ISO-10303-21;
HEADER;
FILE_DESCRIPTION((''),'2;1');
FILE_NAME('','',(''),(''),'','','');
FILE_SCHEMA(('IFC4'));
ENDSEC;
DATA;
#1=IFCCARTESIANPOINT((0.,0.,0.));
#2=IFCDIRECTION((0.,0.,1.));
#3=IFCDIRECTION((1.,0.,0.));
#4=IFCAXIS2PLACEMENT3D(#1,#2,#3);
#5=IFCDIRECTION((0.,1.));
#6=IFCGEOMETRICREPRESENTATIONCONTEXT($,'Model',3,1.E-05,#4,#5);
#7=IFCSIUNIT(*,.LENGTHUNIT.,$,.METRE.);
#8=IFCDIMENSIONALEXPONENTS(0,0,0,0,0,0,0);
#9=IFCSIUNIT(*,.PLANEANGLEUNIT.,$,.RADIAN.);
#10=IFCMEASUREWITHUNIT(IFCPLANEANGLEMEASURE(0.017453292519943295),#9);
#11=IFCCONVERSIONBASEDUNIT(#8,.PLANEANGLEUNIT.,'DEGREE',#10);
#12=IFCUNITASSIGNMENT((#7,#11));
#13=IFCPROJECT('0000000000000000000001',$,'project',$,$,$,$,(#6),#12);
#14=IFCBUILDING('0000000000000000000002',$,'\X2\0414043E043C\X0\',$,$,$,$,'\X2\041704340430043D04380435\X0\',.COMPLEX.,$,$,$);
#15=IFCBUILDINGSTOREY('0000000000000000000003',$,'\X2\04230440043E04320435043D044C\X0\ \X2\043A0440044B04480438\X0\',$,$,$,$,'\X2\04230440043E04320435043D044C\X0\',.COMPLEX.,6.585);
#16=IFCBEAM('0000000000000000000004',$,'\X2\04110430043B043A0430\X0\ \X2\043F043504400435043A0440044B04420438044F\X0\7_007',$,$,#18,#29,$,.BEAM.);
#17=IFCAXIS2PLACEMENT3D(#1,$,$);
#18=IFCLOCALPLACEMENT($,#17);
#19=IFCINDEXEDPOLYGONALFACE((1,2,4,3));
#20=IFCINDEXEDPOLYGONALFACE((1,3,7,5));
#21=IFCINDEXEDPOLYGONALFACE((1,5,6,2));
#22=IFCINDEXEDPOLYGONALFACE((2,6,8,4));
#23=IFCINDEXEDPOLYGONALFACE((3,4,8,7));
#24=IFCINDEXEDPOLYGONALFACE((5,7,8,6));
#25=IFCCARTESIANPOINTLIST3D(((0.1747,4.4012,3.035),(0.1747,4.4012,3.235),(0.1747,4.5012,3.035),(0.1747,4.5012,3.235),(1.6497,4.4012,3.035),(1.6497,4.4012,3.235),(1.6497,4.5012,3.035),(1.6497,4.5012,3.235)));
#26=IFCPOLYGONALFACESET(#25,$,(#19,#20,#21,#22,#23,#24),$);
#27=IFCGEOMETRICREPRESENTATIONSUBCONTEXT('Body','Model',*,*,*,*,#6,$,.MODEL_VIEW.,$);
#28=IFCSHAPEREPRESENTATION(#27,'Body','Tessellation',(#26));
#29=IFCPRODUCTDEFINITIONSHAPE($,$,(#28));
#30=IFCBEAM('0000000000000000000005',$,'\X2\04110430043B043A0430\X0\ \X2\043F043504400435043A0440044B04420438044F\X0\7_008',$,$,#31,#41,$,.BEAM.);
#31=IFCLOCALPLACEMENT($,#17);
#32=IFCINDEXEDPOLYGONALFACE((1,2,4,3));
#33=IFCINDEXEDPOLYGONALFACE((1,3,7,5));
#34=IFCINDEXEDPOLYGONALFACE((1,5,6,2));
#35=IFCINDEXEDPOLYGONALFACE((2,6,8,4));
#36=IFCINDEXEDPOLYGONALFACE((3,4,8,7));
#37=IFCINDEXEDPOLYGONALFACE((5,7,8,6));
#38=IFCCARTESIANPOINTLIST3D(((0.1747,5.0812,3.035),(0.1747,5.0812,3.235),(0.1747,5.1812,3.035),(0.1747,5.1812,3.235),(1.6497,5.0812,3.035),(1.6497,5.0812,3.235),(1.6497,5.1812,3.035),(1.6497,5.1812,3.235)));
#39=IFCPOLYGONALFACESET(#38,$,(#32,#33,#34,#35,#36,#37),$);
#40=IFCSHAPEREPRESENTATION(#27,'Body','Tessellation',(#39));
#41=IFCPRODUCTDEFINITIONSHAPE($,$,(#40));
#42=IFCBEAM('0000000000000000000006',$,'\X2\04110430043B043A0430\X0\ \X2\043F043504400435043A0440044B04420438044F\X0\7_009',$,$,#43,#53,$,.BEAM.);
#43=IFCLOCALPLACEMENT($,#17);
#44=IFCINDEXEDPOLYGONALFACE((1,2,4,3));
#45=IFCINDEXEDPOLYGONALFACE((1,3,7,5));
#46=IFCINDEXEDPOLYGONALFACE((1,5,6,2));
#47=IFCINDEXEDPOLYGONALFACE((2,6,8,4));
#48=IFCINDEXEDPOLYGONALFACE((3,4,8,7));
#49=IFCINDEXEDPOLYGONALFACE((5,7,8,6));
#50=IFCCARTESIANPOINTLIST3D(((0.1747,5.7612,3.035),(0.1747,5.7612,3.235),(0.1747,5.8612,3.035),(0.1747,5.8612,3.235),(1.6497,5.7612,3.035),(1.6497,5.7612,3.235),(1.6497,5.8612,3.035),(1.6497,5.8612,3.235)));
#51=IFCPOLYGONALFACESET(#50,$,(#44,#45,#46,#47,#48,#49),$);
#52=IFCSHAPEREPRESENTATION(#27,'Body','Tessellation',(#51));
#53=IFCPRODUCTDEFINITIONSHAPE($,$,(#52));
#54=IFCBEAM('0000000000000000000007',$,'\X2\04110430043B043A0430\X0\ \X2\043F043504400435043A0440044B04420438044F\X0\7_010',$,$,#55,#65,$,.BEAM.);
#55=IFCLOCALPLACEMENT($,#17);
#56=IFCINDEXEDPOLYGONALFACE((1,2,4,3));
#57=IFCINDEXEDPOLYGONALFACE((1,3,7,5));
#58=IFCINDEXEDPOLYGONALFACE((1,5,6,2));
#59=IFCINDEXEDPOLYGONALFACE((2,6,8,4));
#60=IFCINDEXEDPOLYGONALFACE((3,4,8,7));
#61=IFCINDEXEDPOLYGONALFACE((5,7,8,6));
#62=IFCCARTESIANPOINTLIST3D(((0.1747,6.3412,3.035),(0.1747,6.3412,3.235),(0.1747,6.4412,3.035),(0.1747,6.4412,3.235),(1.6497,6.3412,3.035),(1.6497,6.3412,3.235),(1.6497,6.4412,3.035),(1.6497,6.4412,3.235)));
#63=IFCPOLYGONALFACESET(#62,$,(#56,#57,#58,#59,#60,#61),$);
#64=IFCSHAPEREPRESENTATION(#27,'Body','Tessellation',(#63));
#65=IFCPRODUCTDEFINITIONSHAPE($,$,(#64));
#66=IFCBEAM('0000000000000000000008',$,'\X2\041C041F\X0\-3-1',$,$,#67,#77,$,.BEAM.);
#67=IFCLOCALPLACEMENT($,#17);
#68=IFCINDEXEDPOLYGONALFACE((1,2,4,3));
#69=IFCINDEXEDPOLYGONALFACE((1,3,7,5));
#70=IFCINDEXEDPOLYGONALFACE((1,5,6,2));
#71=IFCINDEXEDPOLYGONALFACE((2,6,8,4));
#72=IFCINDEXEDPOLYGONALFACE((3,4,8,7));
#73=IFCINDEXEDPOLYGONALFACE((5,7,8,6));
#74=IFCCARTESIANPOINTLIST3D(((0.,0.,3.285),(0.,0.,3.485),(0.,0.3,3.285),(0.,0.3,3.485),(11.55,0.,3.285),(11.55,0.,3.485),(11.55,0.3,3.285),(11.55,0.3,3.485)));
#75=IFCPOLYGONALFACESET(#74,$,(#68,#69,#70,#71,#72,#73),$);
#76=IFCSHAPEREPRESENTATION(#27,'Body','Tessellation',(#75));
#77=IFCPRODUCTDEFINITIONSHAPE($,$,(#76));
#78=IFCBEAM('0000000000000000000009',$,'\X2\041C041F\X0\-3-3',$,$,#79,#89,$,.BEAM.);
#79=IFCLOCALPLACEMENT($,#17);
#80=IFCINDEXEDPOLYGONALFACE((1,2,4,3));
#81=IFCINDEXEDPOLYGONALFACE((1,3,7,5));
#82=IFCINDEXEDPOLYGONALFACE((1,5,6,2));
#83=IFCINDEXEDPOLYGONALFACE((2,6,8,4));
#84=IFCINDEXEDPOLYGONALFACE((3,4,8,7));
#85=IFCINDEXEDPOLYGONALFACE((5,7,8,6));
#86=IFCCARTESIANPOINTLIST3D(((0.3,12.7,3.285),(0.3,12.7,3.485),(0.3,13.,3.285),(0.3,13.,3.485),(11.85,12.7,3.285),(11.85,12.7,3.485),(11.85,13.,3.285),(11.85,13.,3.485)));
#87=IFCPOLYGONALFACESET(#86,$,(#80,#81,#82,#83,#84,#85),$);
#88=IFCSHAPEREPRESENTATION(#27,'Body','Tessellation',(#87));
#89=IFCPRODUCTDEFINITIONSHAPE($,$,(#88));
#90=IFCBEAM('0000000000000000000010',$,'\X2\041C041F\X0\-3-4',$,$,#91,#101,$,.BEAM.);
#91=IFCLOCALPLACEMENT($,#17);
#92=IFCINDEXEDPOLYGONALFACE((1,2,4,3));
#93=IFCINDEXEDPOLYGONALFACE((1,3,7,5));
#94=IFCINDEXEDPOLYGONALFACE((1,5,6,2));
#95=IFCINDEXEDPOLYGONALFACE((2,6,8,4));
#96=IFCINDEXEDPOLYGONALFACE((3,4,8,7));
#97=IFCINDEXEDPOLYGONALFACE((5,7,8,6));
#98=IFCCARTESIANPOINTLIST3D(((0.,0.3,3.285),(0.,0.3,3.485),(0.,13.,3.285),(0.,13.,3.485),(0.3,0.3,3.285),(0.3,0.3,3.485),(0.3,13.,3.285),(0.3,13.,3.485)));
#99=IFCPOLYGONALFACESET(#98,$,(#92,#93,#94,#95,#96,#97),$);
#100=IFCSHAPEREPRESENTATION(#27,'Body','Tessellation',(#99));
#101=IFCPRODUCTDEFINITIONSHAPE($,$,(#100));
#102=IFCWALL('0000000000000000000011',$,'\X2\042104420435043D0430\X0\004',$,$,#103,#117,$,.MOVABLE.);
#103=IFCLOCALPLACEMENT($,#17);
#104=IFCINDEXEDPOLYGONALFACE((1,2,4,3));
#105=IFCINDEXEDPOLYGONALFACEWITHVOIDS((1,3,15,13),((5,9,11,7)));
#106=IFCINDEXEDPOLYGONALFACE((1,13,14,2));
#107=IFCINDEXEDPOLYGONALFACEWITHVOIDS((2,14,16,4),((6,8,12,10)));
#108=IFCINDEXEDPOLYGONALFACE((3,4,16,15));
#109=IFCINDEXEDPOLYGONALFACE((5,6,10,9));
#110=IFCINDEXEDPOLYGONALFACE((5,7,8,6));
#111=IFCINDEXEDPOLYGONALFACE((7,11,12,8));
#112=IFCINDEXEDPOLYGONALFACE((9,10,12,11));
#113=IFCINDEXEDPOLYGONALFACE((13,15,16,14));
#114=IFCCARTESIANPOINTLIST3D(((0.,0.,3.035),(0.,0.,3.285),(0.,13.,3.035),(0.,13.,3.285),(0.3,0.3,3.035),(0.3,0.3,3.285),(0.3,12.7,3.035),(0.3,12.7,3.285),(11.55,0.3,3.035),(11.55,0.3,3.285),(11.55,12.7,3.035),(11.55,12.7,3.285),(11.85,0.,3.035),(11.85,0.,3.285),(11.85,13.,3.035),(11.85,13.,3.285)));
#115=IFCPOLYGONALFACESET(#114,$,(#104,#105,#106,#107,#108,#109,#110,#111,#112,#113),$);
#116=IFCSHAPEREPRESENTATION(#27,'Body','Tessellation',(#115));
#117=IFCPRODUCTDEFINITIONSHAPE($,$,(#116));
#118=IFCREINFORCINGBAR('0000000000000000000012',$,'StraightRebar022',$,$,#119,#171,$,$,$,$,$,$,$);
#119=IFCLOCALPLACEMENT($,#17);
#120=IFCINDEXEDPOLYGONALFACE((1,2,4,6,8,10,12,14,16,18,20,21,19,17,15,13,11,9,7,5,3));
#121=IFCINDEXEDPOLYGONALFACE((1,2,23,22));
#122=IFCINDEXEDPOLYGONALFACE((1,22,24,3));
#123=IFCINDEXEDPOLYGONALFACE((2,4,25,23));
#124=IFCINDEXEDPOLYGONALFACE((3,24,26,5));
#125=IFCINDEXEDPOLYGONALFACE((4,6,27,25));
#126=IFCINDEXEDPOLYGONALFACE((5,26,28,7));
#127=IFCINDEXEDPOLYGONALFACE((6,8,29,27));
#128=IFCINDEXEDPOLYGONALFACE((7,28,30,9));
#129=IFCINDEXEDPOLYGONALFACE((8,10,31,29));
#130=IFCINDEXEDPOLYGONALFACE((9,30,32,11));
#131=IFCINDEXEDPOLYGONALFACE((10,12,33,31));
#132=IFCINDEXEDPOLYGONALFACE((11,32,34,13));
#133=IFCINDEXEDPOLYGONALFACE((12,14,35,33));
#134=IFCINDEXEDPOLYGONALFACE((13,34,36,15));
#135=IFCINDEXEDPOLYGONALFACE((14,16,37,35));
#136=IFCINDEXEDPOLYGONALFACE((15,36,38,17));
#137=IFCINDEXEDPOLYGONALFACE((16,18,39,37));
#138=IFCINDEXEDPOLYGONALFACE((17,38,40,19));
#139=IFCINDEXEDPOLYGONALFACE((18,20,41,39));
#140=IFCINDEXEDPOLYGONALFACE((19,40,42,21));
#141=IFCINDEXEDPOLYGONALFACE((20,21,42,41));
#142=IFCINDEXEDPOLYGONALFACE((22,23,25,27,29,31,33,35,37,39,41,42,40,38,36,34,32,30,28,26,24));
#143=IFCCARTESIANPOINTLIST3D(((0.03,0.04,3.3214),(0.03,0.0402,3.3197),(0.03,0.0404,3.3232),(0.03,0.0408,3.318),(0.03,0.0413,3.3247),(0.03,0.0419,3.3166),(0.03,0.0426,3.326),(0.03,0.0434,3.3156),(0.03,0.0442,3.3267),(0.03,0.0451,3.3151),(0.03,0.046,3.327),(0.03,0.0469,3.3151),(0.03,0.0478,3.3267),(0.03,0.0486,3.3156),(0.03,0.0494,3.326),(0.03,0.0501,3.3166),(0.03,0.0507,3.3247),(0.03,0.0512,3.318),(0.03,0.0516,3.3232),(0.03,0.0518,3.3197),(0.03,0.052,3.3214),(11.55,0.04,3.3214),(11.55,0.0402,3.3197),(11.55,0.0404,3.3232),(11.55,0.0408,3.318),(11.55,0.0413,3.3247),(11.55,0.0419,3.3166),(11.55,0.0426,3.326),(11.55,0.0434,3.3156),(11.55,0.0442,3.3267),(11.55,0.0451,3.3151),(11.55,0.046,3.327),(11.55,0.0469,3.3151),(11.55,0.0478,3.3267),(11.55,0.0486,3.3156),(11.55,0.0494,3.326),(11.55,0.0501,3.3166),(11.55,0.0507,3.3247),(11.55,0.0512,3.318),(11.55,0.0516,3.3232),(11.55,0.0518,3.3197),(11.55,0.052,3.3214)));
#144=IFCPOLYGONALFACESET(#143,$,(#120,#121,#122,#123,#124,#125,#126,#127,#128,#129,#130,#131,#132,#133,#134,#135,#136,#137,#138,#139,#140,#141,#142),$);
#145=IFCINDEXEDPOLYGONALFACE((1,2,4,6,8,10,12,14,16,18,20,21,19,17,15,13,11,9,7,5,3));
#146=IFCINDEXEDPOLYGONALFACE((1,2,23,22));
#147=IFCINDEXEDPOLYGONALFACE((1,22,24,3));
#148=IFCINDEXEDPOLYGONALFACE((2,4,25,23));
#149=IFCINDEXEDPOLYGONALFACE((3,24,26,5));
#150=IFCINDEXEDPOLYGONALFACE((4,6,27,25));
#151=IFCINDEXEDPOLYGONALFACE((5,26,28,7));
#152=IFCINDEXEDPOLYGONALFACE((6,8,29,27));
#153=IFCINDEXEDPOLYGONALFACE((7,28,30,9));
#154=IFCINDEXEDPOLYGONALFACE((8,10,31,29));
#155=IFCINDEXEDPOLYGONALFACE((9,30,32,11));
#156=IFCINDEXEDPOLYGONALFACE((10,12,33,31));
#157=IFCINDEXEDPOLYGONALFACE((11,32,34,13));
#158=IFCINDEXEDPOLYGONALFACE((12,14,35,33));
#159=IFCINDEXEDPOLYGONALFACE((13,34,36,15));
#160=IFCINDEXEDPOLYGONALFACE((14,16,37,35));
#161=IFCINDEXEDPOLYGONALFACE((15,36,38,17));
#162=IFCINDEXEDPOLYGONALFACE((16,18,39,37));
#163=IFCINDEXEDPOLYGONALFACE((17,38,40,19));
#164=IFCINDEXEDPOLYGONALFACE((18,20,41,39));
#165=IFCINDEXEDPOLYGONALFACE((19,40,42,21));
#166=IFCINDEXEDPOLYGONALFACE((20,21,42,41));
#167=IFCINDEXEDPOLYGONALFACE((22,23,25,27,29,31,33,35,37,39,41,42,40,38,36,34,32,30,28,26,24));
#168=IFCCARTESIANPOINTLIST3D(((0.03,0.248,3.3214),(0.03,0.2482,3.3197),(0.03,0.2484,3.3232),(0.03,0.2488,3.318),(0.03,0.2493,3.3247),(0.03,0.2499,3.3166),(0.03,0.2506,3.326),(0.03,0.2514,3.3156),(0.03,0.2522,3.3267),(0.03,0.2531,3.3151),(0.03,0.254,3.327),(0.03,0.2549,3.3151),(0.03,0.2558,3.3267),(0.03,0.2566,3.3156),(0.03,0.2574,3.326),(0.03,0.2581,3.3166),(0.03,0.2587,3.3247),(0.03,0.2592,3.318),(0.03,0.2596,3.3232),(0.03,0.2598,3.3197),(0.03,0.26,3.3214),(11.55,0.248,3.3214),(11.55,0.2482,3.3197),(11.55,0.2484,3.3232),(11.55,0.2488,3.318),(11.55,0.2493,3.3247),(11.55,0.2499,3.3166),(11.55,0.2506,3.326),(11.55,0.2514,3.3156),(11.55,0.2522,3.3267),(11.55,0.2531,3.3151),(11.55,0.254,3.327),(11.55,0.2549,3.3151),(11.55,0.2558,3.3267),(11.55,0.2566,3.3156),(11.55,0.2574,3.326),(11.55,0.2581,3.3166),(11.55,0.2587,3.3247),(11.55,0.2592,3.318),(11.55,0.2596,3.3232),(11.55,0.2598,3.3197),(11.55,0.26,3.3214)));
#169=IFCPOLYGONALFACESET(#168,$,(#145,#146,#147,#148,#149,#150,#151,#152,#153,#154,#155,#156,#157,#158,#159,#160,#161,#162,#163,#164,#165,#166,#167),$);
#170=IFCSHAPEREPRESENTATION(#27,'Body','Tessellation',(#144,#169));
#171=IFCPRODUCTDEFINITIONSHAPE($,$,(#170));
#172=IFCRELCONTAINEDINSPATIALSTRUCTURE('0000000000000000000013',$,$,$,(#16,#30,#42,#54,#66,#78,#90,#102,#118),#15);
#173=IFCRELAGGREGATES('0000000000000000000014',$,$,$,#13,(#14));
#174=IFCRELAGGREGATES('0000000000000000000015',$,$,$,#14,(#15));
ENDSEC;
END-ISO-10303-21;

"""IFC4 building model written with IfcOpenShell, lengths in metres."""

from ifc_helpers import new_model, entity, si_unit, converted_unit, direction, frame, frame_2d, origin_with_axes, origin_2d_with_axis, place, context, subcontext, project, spatial, polyline, rectangle, outline, extrude, element, save


model = new_model("IFC4")

# Units and contexts
model_context = context("Model", 3, precision=1e-05, world=origin_with_axes(), true_north=direction((0.0, 1.0)))
body_context = subcontext(model_context, "Body", "Model", "MODEL_VIEW")
ifc_project = project(units=[si_unit("LENGTHUNIT", "METRE"), converted_unit("PLANEANGLEUNIT", "DEGREE", entity("IfcPlaneAngleMeasure", 0.017453292519943295), si_unit("PLANEANGLEUNIT", "RADIAN"), dimensions=[0, 0, 0, 0, 0, 0, 0])], contexts=[model_context])

# Building, storey
building = spatial("IfcBuilding", under=ifc_project, Name="Дом", LongName="Здание", CompositionType="COMPLEX")
storey = spatial("IfcBuildingStorey", under=building, Name="Уровень крыши", LongName="Уровень", CompositionType="COMPLEX", Elevation=6.585)

# Beams
placement = place(None, origin_with_axes())
element("IfcBeam", 1, at=placement, inside=storey, Name="Балка перекрытия7_007", PredefinedType="BEAM", context=body_context, shape_type="SweptSolid", body=[
    extrude(rectangle(XDim=1.475, YDim=0.1, at=origin_2d_with_axis()), frame((0.9122, 4.4512, 3.035), z_axis=(0.0, 0.0, 1.0), x_axis=(1.0, 0.0, 0.0)), (0.0, 0.0, 1.0), 0.2),
])
element("IfcBeam", 2, at=placement, inside=storey, Name="Балка перекрытия7_008", PredefinedType="BEAM", context=body_context, shape_type="SweptSolid", body=[
    extrude(rectangle(XDim=1.475, YDim=0.1, at=origin_2d_with_axis()), frame((0.9122, 5.1312, 3.035), z_axis=(0.0, 0.0, 1.0), x_axis=(1.0, 0.0, 0.0)), (0.0, 0.0, 1.0), 0.2),
])
element("IfcBeam", 3, at=placement, inside=storey, Name="Балка перекрытия7_009", PredefinedType="BEAM", context=body_context, shape_type="SweptSolid", body=[
    extrude(rectangle(XDim=1.475, YDim=0.1, at=origin_2d_with_axis()), frame((0.9122, 5.8112, 3.035), z_axis=(0.0, 0.0, 1.0), x_axis=(1.0, 0.0, 0.0)), (0.0, 0.0, 1.0), 0.2),
])
element("IfcBeam", 4, at=placement, inside=storey, Name="Балка перекрытия7_010", PredefinedType="BEAM", context=body_context, shape_type="SweptSolid", body=[
    extrude(rectangle(XDim=1.475, YDim=0.1, at=origin_2d_with_axis()), frame((0.9122, 6.3912, 3.035), z_axis=(0.0, 0.0, 1.0), x_axis=(1.0, 0.0, 0.0)), (0.0, 0.0, 1.0), 0.2),
])
element("IfcBeam", 5, at=placement, inside=storey, Name="МП-3-1", PredefinedType="BEAM", context=body_context, shape_type="SweptSolid", body=[
    extrude(rectangle(XDim=11.55, YDim=0.3, at=origin_2d_with_axis()), frame((5.775, 0.15, 3.285), z_axis=(0.0, 0.0, 1.0), x_axis=(1.0, 0.0, 0.0)), (0.0, 0.0, 1.0), 0.2),
])
element("IfcBeam", 6, at=placement, inside=storey, Name="МП-3-3", PredefinedType="BEAM", context=body_context, shape_type="SweptSolid", body=[
    extrude(rectangle(XDim=11.55, YDim=0.3, at=origin_2d_with_axis()), frame((6.075, 12.85, 3.285), z_axis=(0.0, 0.0, 1.0), x_axis=(1.0, 0.0, 0.0)), (0.0, 0.0, 1.0), 0.2),
])
element("IfcBeam", 7, at=placement, inside=storey, Name="МП-3-4", PredefinedType="BEAM", context=body_context, shape_type="SweptSolid", body=[
    extrude(rectangle(XDim=0.3, YDim=12.7, at=frame_2d((0.0, 0.0), x_axis=(1.0, 0.0))), frame((0.15, 6.65, 3.285), z_axis=(0.0, 0.0, 1.0), x_axis=(1.0, 0.0, 0.0)), (0.0, 0.0, 1.0), 0.2),
])

# Wall
element("IfcWall", 8, at=placement, inside=storey, Name="Стена004", PredefinedType="MOVABLE", context=body_context, shape_type="SweptSolid", body=[
    extrude(outline(polyline([(-5.925, -6.5), (5.925, -6.5), (5.925, 6.5), (-5.925, 6.5), (-5.925, -6.5)]), holes=[polyline([(5.625, 6.2), (-5.625, 6.2), (-5.625, -6.2), (5.625, -6.2), (5.625, 6.2)])]), frame((5.925, 6.5, 3.035), z_axis=(0.0, 0.0, 1.0), x_axis=(1.0, 0.0, 0.0)), (0.0, 0.0, 1.0), 0.25),
])

# Reinforcing bar
element("IfcReinforcingBar", 9, at=placement, inside=storey, Name="StraightRebar022", context=body_context, shape_type="SweptSolid", body=[
    entity("IfcSweptDiskSolid", entity("IfcCompositeCurve", [entity("IfcCompositeCurveSegment", "CONTINUOUS", True, entity("IfcPolyline", [entity("IfcCartesianPoint", [0.03, 0.046, 3.321]), entity("IfcCartesianPoint", [11.55, 0.046, 3.321])]))], False), 0.006),
    entity("IfcSweptDiskSolid", entity("IfcCompositeCurve", [entity("IfcCompositeCurveSegment", "CONTINUOUS", True, entity("IfcPolyline", [entity("IfcCartesianPoint", [0.03, 0.254, 3.321]), entity("IfcCartesianPoint", [11.55, 0.254, 3.321])]))], False), 0.006),
])

save(model, "model.ifc")
